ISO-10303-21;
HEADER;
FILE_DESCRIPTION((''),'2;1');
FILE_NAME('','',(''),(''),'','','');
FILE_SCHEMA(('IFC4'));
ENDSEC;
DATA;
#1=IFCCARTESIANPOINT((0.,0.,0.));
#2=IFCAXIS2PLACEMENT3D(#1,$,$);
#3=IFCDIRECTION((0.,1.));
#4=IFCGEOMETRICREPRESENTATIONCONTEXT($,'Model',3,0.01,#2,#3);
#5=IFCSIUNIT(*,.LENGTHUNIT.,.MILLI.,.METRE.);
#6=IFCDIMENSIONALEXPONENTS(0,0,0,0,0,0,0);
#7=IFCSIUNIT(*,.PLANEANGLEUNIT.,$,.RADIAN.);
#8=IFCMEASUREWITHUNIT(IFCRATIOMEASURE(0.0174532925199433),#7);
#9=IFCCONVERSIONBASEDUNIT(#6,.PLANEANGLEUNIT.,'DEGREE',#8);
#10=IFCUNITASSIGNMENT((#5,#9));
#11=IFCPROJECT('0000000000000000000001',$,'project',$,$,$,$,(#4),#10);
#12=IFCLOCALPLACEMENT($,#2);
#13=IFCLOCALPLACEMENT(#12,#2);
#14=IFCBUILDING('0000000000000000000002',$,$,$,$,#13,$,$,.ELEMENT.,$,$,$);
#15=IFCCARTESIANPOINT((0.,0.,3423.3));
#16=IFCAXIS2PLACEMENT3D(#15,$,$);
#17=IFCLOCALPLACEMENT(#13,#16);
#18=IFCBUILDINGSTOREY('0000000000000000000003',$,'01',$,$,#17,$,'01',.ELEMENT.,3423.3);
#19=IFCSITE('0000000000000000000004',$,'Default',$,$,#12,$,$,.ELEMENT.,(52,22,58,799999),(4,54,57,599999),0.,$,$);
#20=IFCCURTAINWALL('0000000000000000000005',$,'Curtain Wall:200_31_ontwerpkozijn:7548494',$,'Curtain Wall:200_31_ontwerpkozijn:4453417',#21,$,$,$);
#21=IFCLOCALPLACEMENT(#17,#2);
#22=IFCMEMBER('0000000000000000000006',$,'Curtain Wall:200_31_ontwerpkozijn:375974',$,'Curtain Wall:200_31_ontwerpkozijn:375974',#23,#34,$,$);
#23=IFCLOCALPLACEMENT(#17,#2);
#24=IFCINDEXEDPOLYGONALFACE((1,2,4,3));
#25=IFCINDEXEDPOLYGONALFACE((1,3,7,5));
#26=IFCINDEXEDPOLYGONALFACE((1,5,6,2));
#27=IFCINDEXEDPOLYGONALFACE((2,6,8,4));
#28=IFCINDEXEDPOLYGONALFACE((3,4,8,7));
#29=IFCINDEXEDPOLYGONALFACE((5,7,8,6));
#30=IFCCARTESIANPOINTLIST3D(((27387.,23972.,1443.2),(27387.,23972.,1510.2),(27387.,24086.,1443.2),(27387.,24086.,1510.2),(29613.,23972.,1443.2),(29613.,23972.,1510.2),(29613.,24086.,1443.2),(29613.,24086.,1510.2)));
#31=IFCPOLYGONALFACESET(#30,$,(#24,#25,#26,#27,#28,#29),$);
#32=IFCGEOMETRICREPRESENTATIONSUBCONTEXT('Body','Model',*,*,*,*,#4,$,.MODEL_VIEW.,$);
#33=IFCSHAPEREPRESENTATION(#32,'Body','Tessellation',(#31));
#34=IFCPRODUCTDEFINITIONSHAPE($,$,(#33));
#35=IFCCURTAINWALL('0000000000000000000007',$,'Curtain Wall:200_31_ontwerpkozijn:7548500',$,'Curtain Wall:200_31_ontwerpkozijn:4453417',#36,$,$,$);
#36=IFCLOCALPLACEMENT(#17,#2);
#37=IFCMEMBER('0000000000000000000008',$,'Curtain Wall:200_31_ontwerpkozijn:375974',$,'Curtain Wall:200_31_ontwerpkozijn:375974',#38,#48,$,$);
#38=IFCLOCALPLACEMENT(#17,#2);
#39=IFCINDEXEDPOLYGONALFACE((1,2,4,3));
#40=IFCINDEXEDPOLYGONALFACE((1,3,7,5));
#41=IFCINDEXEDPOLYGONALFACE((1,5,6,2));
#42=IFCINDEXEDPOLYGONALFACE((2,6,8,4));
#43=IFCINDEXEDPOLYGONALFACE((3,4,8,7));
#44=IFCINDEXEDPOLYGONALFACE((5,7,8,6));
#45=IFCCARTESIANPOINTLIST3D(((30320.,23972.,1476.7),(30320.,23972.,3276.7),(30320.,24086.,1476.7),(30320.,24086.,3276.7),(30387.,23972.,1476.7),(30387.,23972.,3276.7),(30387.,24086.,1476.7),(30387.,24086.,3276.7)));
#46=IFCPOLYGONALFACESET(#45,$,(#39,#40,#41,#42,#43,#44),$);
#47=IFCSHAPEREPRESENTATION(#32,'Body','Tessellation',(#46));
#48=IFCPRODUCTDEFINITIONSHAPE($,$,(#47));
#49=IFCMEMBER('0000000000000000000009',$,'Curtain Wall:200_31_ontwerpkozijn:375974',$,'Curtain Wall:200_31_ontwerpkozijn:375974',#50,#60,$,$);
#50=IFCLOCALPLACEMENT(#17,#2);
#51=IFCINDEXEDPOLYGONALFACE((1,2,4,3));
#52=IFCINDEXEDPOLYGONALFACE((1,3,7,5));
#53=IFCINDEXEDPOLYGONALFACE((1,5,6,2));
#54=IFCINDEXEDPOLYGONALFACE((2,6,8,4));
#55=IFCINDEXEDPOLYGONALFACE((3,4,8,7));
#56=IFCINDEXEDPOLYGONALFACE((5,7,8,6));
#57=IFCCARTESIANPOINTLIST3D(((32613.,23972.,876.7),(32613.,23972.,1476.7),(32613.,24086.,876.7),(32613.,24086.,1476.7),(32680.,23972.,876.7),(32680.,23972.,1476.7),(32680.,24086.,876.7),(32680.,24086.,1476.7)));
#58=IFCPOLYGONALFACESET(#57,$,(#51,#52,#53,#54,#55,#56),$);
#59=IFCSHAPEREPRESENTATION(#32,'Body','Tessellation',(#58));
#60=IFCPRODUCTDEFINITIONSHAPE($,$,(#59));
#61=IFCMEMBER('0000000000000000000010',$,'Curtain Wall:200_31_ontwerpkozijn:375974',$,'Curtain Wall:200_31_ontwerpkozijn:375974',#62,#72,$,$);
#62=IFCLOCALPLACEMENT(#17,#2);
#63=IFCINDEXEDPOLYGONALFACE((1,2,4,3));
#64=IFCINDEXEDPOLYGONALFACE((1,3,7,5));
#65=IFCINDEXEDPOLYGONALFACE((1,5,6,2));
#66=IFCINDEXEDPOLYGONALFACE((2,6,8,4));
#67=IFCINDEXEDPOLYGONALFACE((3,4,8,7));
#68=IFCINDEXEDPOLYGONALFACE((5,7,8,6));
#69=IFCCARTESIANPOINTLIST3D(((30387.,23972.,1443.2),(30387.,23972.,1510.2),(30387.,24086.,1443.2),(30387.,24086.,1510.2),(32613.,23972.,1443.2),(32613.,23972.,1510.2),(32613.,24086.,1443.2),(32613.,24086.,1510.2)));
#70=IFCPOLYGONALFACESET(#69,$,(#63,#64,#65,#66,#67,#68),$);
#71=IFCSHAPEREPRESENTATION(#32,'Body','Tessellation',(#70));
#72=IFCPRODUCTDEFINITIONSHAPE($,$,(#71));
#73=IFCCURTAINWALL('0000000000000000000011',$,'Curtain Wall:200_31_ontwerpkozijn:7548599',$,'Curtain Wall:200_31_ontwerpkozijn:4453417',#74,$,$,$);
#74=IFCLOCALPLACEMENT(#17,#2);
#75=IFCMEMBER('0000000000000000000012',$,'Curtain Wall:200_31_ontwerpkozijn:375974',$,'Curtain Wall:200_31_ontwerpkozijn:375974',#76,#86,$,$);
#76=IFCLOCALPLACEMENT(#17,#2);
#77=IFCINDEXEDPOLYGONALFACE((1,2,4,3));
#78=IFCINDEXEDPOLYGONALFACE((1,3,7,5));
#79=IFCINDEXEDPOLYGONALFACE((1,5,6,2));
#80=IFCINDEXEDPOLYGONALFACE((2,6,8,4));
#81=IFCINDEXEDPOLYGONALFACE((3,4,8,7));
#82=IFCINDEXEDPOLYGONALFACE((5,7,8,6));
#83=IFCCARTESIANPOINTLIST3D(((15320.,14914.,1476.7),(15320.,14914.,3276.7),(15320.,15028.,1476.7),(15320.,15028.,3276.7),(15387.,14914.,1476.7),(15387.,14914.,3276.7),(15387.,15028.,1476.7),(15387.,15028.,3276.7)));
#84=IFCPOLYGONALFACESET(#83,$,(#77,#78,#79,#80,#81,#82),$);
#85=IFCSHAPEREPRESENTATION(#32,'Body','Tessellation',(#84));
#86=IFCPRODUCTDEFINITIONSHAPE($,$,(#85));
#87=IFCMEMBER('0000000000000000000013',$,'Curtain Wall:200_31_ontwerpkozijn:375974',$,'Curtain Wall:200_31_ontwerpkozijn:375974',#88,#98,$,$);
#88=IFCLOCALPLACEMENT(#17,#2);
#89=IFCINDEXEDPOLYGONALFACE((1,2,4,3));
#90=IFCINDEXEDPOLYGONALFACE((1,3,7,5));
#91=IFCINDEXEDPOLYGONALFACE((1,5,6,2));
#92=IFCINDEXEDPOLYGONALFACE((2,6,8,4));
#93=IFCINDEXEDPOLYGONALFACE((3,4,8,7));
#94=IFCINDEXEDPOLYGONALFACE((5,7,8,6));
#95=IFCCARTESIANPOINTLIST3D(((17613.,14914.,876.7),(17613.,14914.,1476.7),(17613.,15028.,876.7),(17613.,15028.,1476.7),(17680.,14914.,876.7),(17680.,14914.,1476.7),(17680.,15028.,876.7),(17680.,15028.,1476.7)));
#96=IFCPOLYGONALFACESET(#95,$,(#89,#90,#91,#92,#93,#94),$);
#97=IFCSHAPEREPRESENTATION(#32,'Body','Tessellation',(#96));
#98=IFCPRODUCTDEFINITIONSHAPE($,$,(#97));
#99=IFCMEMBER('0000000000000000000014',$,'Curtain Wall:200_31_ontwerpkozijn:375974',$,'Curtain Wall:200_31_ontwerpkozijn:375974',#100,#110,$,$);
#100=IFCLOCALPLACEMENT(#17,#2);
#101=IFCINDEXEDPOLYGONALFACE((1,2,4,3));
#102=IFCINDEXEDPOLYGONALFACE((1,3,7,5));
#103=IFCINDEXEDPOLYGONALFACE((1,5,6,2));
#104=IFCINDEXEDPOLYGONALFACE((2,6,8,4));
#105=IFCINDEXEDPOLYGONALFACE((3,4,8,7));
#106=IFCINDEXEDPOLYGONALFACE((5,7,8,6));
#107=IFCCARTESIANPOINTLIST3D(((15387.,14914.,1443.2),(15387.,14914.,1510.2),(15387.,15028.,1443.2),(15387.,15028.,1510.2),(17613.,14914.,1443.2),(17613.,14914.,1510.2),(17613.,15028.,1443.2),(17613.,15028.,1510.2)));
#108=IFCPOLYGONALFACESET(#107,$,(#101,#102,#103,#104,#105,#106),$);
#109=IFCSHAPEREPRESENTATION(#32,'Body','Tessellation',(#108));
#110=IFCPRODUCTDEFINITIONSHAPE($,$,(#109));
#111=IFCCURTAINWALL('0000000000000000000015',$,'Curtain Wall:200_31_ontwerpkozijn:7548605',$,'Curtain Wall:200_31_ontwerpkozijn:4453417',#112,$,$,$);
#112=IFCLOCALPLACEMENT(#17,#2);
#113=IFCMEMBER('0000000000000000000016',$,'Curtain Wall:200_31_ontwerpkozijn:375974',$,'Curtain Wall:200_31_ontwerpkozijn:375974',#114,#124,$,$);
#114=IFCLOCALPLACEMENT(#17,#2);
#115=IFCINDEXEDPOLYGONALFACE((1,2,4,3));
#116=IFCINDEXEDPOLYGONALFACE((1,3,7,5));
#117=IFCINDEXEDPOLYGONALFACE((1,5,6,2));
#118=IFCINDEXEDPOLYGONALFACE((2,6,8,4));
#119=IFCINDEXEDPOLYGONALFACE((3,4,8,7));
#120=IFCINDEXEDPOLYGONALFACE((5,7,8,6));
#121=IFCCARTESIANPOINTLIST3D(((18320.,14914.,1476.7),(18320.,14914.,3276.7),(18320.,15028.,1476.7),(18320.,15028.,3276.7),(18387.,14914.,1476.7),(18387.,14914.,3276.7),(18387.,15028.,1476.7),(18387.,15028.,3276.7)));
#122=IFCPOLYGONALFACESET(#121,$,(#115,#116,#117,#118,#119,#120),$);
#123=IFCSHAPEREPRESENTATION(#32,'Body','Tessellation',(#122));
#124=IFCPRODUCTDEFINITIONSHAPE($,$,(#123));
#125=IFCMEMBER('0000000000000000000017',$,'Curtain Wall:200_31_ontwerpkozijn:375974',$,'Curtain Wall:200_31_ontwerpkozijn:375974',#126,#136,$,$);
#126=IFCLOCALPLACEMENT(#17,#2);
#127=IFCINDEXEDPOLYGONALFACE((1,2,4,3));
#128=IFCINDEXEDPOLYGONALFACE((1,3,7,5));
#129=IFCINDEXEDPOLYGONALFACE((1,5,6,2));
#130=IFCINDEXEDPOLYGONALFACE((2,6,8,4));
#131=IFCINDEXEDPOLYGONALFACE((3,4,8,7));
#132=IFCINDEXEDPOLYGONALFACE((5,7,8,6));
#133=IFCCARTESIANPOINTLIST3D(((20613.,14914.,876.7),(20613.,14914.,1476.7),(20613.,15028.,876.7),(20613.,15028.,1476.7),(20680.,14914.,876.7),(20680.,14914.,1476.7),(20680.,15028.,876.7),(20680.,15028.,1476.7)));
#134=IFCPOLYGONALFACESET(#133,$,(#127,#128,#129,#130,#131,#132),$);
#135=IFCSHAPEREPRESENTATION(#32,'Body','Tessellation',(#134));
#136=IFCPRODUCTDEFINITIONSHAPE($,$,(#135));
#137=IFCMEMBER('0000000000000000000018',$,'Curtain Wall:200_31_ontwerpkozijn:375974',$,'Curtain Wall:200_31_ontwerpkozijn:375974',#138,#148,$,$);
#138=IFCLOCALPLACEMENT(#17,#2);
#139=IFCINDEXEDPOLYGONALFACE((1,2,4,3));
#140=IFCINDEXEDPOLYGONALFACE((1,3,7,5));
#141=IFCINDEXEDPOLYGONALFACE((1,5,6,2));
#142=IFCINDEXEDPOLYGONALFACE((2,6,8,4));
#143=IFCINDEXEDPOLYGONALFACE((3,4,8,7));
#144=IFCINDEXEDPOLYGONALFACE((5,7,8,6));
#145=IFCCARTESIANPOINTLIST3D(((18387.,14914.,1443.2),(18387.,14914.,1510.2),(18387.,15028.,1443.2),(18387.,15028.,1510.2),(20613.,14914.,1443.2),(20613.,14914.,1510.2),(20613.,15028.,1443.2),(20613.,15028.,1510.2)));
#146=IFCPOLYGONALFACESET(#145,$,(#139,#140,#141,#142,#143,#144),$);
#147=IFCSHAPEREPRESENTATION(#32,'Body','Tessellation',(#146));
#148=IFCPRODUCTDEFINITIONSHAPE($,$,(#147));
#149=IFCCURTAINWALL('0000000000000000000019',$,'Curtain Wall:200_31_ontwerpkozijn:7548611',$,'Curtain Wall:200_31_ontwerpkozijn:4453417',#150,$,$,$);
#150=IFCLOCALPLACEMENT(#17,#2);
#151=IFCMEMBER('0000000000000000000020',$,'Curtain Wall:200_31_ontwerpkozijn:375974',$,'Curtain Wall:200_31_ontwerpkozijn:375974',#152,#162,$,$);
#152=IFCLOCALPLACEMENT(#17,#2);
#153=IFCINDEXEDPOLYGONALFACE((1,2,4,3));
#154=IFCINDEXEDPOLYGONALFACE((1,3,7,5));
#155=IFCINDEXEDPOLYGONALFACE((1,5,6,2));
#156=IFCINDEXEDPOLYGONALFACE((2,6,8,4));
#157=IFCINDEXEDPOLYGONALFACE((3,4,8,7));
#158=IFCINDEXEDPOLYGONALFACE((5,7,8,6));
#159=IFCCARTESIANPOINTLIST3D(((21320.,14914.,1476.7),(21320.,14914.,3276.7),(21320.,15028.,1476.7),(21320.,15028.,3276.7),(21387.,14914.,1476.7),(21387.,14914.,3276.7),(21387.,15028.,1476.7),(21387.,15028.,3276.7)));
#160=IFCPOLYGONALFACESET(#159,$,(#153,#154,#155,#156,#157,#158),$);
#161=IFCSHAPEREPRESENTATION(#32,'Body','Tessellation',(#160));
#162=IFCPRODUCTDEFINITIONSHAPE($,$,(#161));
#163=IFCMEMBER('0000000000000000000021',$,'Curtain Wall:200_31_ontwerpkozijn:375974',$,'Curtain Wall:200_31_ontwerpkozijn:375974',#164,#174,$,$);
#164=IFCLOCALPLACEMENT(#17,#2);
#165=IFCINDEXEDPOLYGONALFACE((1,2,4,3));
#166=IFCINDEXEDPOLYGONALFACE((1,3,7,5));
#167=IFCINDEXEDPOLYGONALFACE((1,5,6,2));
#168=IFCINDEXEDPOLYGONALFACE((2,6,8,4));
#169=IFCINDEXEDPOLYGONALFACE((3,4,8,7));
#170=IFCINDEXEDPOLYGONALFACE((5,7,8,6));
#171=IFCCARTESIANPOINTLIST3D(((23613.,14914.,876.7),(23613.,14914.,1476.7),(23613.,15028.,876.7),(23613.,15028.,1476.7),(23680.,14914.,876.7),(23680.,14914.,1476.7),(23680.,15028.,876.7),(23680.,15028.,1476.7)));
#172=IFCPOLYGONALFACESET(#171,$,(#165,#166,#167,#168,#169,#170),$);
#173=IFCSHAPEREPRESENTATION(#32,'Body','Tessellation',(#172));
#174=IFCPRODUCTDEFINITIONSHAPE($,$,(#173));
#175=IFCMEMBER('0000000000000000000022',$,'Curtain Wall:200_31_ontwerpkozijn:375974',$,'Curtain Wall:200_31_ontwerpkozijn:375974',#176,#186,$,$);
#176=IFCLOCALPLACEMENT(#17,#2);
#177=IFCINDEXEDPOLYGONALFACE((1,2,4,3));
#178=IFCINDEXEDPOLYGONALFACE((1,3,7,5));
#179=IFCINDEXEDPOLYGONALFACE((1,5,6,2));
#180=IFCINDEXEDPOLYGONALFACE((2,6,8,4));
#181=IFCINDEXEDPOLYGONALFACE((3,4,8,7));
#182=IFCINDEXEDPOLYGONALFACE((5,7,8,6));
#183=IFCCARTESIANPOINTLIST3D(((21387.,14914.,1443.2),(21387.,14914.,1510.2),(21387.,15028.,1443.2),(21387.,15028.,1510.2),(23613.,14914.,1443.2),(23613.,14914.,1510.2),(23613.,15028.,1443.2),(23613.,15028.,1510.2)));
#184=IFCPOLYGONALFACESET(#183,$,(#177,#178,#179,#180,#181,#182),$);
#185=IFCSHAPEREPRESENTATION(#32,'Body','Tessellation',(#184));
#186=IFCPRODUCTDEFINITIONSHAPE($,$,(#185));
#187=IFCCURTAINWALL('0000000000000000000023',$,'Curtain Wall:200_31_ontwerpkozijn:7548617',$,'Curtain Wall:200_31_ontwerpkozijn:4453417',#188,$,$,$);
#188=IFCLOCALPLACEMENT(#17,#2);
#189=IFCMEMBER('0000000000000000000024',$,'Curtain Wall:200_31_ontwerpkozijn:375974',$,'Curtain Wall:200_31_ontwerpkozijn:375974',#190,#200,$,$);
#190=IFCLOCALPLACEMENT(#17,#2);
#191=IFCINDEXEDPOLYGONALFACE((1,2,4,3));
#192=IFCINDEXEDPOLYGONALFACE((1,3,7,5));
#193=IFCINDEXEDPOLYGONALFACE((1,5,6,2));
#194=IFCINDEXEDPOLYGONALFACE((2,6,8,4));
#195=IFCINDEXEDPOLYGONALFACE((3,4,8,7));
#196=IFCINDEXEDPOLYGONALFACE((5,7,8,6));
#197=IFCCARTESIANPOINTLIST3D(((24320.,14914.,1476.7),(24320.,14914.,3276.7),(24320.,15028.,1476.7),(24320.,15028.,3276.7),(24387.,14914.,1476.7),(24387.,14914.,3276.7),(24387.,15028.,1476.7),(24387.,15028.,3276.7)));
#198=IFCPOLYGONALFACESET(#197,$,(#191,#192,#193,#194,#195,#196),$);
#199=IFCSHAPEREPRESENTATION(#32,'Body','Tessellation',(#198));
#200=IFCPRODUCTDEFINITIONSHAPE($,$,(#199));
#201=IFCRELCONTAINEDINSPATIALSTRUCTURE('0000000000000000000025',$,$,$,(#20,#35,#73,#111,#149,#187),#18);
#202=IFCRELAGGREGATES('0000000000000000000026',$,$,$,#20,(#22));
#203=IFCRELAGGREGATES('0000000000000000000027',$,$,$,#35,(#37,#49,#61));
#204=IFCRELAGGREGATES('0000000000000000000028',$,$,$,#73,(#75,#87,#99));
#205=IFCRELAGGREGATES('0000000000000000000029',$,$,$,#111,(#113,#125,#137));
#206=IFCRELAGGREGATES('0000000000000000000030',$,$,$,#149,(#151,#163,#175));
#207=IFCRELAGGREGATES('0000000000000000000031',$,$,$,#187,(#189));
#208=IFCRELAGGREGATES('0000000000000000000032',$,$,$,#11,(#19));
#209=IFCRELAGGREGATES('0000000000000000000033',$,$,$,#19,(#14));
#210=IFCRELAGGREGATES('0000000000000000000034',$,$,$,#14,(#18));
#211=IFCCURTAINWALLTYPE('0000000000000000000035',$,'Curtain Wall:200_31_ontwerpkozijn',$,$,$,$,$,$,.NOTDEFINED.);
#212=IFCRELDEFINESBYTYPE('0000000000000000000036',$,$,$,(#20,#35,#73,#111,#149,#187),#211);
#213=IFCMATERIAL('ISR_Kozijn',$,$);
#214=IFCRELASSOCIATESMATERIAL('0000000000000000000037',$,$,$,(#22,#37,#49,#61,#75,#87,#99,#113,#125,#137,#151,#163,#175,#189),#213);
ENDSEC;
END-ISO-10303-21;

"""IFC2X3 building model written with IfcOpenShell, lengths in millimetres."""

from ifc_helpers import new_model, entity, si_unit, converted_unit, direction, frame, frame_2d, origin, origin_2d_with_axis, place, context, subcontext, project, spatial, rectangle, extrude, material, type_object, element, aggregate, save


model = new_model("IFC2X3")

# Units and contexts
model_context = context("Model", 3, precision=0.01, world=origin(), true_north=direction((0.0, 1.0)))
body_context = subcontext(model_context, "Body", "Model", "MODEL_VIEW")
ifc_project = project(units=[si_unit("LENGTHUNIT", "METRE", prefix="MILLI"), converted_unit("PLANEANGLEUNIT", "DEGREE", entity("IfcRatioMeasure", 0.0174532925199433), si_unit("PLANEANGLEUNIT", "RADIAN"), dimensions=[0, 0, 0, 0, 0, 0, 0])], contexts=[model_context])

# Site, building, storey
site_placement = place(None, origin())
site = spatial("IfcSite", under=ifc_project, at=site_placement, Name="Default", CompositionType="ELEMENT", RefLatitude=(52, 22, 58, 799999), RefLongitude=(4, 54, 57, 599999), RefElevation=0.0)
building_placement = place(site_placement, origin())
building = spatial("IfcBuilding", under=site, at=building_placement, CompositionType="ELEMENT")
storey_placement = place(building_placement, frame((0.0, 0.0, 3423.3)))
storey = spatial("IfcBuildingStorey", under=building, at=storey_placement, Name="01", LongName="01", CompositionType="ELEMENT", Elevation=3423.3)

# Curtain walls, members
curtain_wall_type = type_object("IfcCurtainWallType", Name="Curtain Wall:200_31_ontwerpkozijn", PredefinedType="NOTDEFINED")
ifc_material_1 = material(Name="ISR_Kozijn")
curtain_wall_1_placement = place(storey_placement, frame((0.0, 0.0, -3423.3)))
curtain_wall_1 = element("IfcCurtainWall", 1, at=curtain_wall_1_placement, inside=storey, type_object=curtain_wall_type, Name="Curtain Wall:200_31_ontwerpkozijn:7548494", ObjectType="Curtain Wall:200_31_ontwerpkozijn:4453417")
member_1_placement = place(curtain_wall_1_placement, frame((0.0, 0.0, 3423.3)))
member_1 = element("IfcMember", 2, at=member_1_placement, material=ifc_material_1, Name="Curtain Wall:200_31_ontwerpkozijn:375974", ObjectType="Curtain Wall:200_31_ontwerpkozijn:375974", context=body_context, shape_type="SweptSolid", body=[
    extrude(rectangle(XDim=67.0, YDim=114.0, at=origin_2d_with_axis()), frame((27387.0, 24029.0, 1476.7), z_axis=(1.0, 0.0, 0.0), x_axis=(0.0, 0.0, -1.0)), (0.0, 0.0, 1.0), 2226.0),
])
aggregate(curtain_wall_1, [member_1])
curtain_wall_2_placement = place(storey_placement, frame((0.0, 0.0, -3423.3)))
curtain_wall_2 = element("IfcCurtainWall", 3, at=curtain_wall_2_placement, inside=storey, type_object=curtain_wall_type, Name="Curtain Wall:200_31_ontwerpkozijn:7548500", ObjectType="Curtain Wall:200_31_ontwerpkozijn:4453417")
member_2_placement = place(curtain_wall_2_placement, frame((0.0, 0.0, 3423.3)))
member_2 = element("IfcMember", 4, at=member_2_placement, material=ifc_material_1, Name="Curtain Wall:200_31_ontwerpkozijn:375974", ObjectType="Curtain Wall:200_31_ontwerpkozijn:375974", context=body_context, shape_type="SweptSolid", body=[
    extrude(rectangle(XDim=67.0, YDim=114.0, at=origin_2d_with_axis()), frame((30353.5, 24029.0, 1476.7), z_axis=(0.0, 0.0, 1.0), x_axis=(-1.0, 0.0, 0.0)), (0.0, 0.0, 1.0), 1800.0),
])
member_3_placement = place(curtain_wall_2_placement, frame((0.0, 0.0, 3423.3)))
member_3 = element("IfcMember", 5, at=member_3_placement, material=ifc_material_1, Name="Curtain Wall:200_31_ontwerpkozijn:375974", ObjectType="Curtain Wall:200_31_ontwerpkozijn:375974", context=body_context, shape_type="SweptSolid", body=[
    extrude(rectangle(XDim=67.0, YDim=114.0, at=origin_2d_with_axis()), frame((32646.5, 24029.0, 1476.7), z_axis=(0.0, 0.0, -1.0), x_axis=(-1.0, 0.0, 0.0)), (0.0, 0.0, 1.0), 600.0),
])
member_4_placement = place(curtain_wall_2_placement, frame((0.0, 0.0, 3423.3)))
member_4 = element("IfcMember", 6, at=member_4_placement, material=ifc_material_1, Name="Curtain Wall:200_31_ontwerpkozijn:375974", ObjectType="Curtain Wall:200_31_ontwerpkozijn:375974", context=body_context, shape_type="SweptSolid", body=[
    extrude(rectangle(XDim=67.0, YDim=114.0, at=origin_2d_with_axis()), frame((30387.0, 24029.0, 1476.7), z_axis=(1.0, 0.0, 0.0), x_axis=(0.0, 0.0, -1.0)), (0.0, 0.0, 1.0), 2226.0),
])
aggregate(curtain_wall_2, [member_2, member_3, member_4])
curtain_wall_3_placement = place(storey_placement, frame((0.0, 0.0, -3423.3)))
curtain_wall_3 = element("IfcCurtainWall", 7, at=curtain_wall_3_placement, inside=storey, type_object=curtain_wall_type, Name="Curtain Wall:200_31_ontwerpkozijn:7548599", ObjectType="Curtain Wall:200_31_ontwerpkozijn:4453417")
member_5_placement = place(curtain_wall_3_placement, frame((0.0, 0.0, 3423.3)))
member_5 = element("IfcMember", 8, at=member_5_placement, material=ifc_material_1, Name="Curtain Wall:200_31_ontwerpkozijn:375974", ObjectType="Curtain Wall:200_31_ontwerpkozijn:375974", context=body_context, shape_type="SweptSolid", body=[
    extrude(rectangle(XDim=67.0, YDim=114.0, at=frame_2d((0.0, 0.0), x_axis=(1.0, 0.0))), frame((15353.5, 14971.0, 1476.7), z_axis=(0.0, 0.0, 1.0), x_axis=(-1.0, 0.0, 0.0)), (0.0, 0.0, 1.0), 1800.0),
])
member_6_placement = place(curtain_wall_3_placement, frame((0.0, 0.0, 3423.3)))
member_6 = element("IfcMember", 9, at=member_6_placement, material=ifc_material_1, Name="Curtain Wall:200_31_ontwerpkozijn:375974", ObjectType="Curtain Wall:200_31_ontwerpkozijn:375974", context=body_context, shape_type="SweptSolid", body=[
    extrude(rectangle(XDim=67.0, YDim=114.0, at=frame_2d((0.0, 0.0), x_axis=(1.0, 0.0))), frame((17646.5, 14971.0, 1476.7), z_axis=(0.0, 0.0, -1.0), x_axis=(-1.0, 0.0, 0.0)), (0.0, 0.0, 1.0), 600.0),
])
member_7_placement = place(curtain_wall_3_placement, frame((0.0, 0.0, 3423.3)))
member_7 = element("IfcMember", 10, at=member_7_placement, material=ifc_material_1, Name="Curtain Wall:200_31_ontwerpkozijn:375974", ObjectType="Curtain Wall:200_31_ontwerpkozijn:375974", context=body_context, shape_type="SweptSolid", body=[
    extrude(rectangle(XDim=67.0, YDim=114.0, at=frame_2d((0.0, 0.0), x_axis=(1.0, 0.0))), frame((15387.0, 14971.0, 1476.7), z_axis=(1.0, 0.0, 0.0), x_axis=(0.0, 0.0, -1.0)), (0.0, 0.0, 1.0), 2226.0),
])
aggregate(curtain_wall_3, [member_5, member_6, member_7])
curtain_wall_4_placement = place(storey_placement, frame((0.0, 0.0, -3423.3)))
curtain_wall_4 = element("IfcCurtainWall", 11, at=curtain_wall_4_placement, inside=storey, type_object=curtain_wall_type, Name="Curtain Wall:200_31_ontwerpkozijn:7548605", ObjectType="Curtain Wall:200_31_ontwerpkozijn:4453417")
member_8_placement = place(curtain_wall_4_placement, frame((0.0, 0.0, 3423.3)))
member_8 = element("IfcMember", 12, at=member_8_placement, material=ifc_material_1, Name="Curtain Wall:200_31_ontwerpkozijn:375974", ObjectType="Curtain Wall:200_31_ontwerpkozijn:375974", context=body_context, shape_type="SweptSolid", body=[
    extrude(rectangle(XDim=67.0, YDim=114.0, at=frame_2d((0.0, 0.0), x_axis=(1.0, 0.0))), frame((18353.5, 14971.0, 1476.7), z_axis=(0.0, 0.0, 1.0), x_axis=(-1.0, 0.0, 0.0)), (0.0, 0.0, 1.0), 1800.0),
])
member_9_placement = place(curtain_wall_4_placement, frame((0.0, 0.0, 3423.3)))
member_9 = element("IfcMember", 13, at=member_9_placement, material=ifc_material_1, Name="Curtain Wall:200_31_ontwerpkozijn:375974", ObjectType="Curtain Wall:200_31_ontwerpkozijn:375974", context=body_context, shape_type="SweptSolid", body=[
    extrude(rectangle(XDim=67.0, YDim=114.0, at=origin_2d_with_axis()), frame((20646.5, 14971.0, 1476.7), z_axis=(0.0, 0.0, -1.0), x_axis=(-1.0, 0.0, 0.0)), (0.0, 0.0, 1.0), 600.0),
])
member_10_placement = place(curtain_wall_4_placement, frame((0.0, 0.0, 3423.3)))
member_10 = element("IfcMember", 14, at=member_10_placement, material=ifc_material_1, Name="Curtain Wall:200_31_ontwerpkozijn:375974", ObjectType="Curtain Wall:200_31_ontwerpkozijn:375974", context=body_context, shape_type="SweptSolid", body=[
    extrude(rectangle(XDim=67.0, YDim=114.0, at=frame_2d((0.0, 0.0), x_axis=(1.0, 0.0))), frame((18387.0, 14971.0, 1476.7), z_axis=(1.0, 0.0, 0.0), x_axis=(0.0, 0.0, -1.0)), (0.0, 0.0, 1.0), 2226.0),
])
aggregate(curtain_wall_4, [member_8, member_9, member_10])
curtain_wall_5_placement = place(storey_placement, frame((0.0, 0.0, -3423.3)))
curtain_wall_5 = element("IfcCurtainWall", 15, at=curtain_wall_5_placement, inside=storey, type_object=curtain_wall_type, Name="Curtain Wall:200_31_ontwerpkozijn:7548611", ObjectType="Curtain Wall:200_31_ontwerpkozijn:4453417")
member_11_placement = place(curtain_wall_5_placement, frame((0.0, 0.0, 3423.3)))
member_11 = element("IfcMember", 16, at=member_11_placement, material=ifc_material_1, Name="Curtain Wall:200_31_ontwerpkozijn:375974", ObjectType="Curtain Wall:200_31_ontwerpkozijn:375974", context=body_context, shape_type="SweptSolid", body=[
    extrude(rectangle(XDim=67.0, YDim=114.0, at=origin_2d_with_axis()), frame((21353.5, 14971.0, 1476.7), z_axis=(0.0, 0.0, 1.0), x_axis=(-1.0, 0.0, 0.0)), (0.0, 0.0, 1.0), 1800.0),
])
member_12_placement = place(curtain_wall_5_placement, frame((0.0, 0.0, 3423.3)))
member_12 = element("IfcMember", 17, at=member_12_placement, material=ifc_material_1, Name="Curtain Wall:200_31_ontwerpkozijn:375974", ObjectType="Curtain Wall:200_31_ontwerpkozijn:375974", context=body_context, shape_type="SweptSolid", body=[
    extrude(rectangle(XDim=67.0, YDim=114.0, at=origin_2d_with_axis()), frame((23646.5, 14971.0, 1476.7), z_axis=(0.0, 0.0, -1.0), x_axis=(-1.0, 0.0, 0.0)), (0.0, 0.0, 1.0), 600.0),
])
member_13_placement = place(curtain_wall_5_placement, frame((0.0, 0.0, 3423.3)))
member_13 = element("IfcMember", 18, at=member_13_placement, material=ifc_material_1, Name="Curtain Wall:200_31_ontwerpkozijn:375974", ObjectType="Curtain Wall:200_31_ontwerpkozijn:375974", context=body_context, shape_type="SweptSolid", body=[
    extrude(rectangle(XDim=67.0, YDim=114.0, at=frame_2d((0.0, 0.0), x_axis=(1.0, 0.0))), frame((21387.0, 14971.0, 1476.7), z_axis=(1.0, 0.0, 0.0), x_axis=(0.0, 0.0, -1.0)), (0.0, 0.0, 1.0), 2226.0),
])
aggregate(curtain_wall_5, [member_11, member_12, member_13])
curtain_wall_6_placement = place(storey_placement, frame((0.0, 0.0, -3423.3)))
curtain_wall_6 = element("IfcCurtainWall", 19, at=curtain_wall_6_placement, inside=storey, type_object=curtain_wall_type, Name="Curtain Wall:200_31_ontwerpkozijn:7548617", ObjectType="Curtain Wall:200_31_ontwerpkozijn:4453417")
member_14_placement = place(curtain_wall_6_placement, frame((0.0, 0.0, 3423.3)))
member_14 = element("IfcMember", 20, at=member_14_placement, material=ifc_material_1, Name="Curtain Wall:200_31_ontwerpkozijn:375974", ObjectType="Curtain Wall:200_31_ontwerpkozijn:375974", context=body_context, shape_type="SweptSolid", body=[
    extrude(rectangle(XDim=67.0, YDim=114.0, at=origin_2d_with_axis()), frame((24353.5, 14971.0, 1476.7), z_axis=(0.0, 0.0, 1.0), x_axis=(-1.0, 0.0, 0.0)), (0.0, 0.0, 1.0), 1800.0),
])
aggregate(curtain_wall_6, [member_14])

save(model, "model.ifc")
